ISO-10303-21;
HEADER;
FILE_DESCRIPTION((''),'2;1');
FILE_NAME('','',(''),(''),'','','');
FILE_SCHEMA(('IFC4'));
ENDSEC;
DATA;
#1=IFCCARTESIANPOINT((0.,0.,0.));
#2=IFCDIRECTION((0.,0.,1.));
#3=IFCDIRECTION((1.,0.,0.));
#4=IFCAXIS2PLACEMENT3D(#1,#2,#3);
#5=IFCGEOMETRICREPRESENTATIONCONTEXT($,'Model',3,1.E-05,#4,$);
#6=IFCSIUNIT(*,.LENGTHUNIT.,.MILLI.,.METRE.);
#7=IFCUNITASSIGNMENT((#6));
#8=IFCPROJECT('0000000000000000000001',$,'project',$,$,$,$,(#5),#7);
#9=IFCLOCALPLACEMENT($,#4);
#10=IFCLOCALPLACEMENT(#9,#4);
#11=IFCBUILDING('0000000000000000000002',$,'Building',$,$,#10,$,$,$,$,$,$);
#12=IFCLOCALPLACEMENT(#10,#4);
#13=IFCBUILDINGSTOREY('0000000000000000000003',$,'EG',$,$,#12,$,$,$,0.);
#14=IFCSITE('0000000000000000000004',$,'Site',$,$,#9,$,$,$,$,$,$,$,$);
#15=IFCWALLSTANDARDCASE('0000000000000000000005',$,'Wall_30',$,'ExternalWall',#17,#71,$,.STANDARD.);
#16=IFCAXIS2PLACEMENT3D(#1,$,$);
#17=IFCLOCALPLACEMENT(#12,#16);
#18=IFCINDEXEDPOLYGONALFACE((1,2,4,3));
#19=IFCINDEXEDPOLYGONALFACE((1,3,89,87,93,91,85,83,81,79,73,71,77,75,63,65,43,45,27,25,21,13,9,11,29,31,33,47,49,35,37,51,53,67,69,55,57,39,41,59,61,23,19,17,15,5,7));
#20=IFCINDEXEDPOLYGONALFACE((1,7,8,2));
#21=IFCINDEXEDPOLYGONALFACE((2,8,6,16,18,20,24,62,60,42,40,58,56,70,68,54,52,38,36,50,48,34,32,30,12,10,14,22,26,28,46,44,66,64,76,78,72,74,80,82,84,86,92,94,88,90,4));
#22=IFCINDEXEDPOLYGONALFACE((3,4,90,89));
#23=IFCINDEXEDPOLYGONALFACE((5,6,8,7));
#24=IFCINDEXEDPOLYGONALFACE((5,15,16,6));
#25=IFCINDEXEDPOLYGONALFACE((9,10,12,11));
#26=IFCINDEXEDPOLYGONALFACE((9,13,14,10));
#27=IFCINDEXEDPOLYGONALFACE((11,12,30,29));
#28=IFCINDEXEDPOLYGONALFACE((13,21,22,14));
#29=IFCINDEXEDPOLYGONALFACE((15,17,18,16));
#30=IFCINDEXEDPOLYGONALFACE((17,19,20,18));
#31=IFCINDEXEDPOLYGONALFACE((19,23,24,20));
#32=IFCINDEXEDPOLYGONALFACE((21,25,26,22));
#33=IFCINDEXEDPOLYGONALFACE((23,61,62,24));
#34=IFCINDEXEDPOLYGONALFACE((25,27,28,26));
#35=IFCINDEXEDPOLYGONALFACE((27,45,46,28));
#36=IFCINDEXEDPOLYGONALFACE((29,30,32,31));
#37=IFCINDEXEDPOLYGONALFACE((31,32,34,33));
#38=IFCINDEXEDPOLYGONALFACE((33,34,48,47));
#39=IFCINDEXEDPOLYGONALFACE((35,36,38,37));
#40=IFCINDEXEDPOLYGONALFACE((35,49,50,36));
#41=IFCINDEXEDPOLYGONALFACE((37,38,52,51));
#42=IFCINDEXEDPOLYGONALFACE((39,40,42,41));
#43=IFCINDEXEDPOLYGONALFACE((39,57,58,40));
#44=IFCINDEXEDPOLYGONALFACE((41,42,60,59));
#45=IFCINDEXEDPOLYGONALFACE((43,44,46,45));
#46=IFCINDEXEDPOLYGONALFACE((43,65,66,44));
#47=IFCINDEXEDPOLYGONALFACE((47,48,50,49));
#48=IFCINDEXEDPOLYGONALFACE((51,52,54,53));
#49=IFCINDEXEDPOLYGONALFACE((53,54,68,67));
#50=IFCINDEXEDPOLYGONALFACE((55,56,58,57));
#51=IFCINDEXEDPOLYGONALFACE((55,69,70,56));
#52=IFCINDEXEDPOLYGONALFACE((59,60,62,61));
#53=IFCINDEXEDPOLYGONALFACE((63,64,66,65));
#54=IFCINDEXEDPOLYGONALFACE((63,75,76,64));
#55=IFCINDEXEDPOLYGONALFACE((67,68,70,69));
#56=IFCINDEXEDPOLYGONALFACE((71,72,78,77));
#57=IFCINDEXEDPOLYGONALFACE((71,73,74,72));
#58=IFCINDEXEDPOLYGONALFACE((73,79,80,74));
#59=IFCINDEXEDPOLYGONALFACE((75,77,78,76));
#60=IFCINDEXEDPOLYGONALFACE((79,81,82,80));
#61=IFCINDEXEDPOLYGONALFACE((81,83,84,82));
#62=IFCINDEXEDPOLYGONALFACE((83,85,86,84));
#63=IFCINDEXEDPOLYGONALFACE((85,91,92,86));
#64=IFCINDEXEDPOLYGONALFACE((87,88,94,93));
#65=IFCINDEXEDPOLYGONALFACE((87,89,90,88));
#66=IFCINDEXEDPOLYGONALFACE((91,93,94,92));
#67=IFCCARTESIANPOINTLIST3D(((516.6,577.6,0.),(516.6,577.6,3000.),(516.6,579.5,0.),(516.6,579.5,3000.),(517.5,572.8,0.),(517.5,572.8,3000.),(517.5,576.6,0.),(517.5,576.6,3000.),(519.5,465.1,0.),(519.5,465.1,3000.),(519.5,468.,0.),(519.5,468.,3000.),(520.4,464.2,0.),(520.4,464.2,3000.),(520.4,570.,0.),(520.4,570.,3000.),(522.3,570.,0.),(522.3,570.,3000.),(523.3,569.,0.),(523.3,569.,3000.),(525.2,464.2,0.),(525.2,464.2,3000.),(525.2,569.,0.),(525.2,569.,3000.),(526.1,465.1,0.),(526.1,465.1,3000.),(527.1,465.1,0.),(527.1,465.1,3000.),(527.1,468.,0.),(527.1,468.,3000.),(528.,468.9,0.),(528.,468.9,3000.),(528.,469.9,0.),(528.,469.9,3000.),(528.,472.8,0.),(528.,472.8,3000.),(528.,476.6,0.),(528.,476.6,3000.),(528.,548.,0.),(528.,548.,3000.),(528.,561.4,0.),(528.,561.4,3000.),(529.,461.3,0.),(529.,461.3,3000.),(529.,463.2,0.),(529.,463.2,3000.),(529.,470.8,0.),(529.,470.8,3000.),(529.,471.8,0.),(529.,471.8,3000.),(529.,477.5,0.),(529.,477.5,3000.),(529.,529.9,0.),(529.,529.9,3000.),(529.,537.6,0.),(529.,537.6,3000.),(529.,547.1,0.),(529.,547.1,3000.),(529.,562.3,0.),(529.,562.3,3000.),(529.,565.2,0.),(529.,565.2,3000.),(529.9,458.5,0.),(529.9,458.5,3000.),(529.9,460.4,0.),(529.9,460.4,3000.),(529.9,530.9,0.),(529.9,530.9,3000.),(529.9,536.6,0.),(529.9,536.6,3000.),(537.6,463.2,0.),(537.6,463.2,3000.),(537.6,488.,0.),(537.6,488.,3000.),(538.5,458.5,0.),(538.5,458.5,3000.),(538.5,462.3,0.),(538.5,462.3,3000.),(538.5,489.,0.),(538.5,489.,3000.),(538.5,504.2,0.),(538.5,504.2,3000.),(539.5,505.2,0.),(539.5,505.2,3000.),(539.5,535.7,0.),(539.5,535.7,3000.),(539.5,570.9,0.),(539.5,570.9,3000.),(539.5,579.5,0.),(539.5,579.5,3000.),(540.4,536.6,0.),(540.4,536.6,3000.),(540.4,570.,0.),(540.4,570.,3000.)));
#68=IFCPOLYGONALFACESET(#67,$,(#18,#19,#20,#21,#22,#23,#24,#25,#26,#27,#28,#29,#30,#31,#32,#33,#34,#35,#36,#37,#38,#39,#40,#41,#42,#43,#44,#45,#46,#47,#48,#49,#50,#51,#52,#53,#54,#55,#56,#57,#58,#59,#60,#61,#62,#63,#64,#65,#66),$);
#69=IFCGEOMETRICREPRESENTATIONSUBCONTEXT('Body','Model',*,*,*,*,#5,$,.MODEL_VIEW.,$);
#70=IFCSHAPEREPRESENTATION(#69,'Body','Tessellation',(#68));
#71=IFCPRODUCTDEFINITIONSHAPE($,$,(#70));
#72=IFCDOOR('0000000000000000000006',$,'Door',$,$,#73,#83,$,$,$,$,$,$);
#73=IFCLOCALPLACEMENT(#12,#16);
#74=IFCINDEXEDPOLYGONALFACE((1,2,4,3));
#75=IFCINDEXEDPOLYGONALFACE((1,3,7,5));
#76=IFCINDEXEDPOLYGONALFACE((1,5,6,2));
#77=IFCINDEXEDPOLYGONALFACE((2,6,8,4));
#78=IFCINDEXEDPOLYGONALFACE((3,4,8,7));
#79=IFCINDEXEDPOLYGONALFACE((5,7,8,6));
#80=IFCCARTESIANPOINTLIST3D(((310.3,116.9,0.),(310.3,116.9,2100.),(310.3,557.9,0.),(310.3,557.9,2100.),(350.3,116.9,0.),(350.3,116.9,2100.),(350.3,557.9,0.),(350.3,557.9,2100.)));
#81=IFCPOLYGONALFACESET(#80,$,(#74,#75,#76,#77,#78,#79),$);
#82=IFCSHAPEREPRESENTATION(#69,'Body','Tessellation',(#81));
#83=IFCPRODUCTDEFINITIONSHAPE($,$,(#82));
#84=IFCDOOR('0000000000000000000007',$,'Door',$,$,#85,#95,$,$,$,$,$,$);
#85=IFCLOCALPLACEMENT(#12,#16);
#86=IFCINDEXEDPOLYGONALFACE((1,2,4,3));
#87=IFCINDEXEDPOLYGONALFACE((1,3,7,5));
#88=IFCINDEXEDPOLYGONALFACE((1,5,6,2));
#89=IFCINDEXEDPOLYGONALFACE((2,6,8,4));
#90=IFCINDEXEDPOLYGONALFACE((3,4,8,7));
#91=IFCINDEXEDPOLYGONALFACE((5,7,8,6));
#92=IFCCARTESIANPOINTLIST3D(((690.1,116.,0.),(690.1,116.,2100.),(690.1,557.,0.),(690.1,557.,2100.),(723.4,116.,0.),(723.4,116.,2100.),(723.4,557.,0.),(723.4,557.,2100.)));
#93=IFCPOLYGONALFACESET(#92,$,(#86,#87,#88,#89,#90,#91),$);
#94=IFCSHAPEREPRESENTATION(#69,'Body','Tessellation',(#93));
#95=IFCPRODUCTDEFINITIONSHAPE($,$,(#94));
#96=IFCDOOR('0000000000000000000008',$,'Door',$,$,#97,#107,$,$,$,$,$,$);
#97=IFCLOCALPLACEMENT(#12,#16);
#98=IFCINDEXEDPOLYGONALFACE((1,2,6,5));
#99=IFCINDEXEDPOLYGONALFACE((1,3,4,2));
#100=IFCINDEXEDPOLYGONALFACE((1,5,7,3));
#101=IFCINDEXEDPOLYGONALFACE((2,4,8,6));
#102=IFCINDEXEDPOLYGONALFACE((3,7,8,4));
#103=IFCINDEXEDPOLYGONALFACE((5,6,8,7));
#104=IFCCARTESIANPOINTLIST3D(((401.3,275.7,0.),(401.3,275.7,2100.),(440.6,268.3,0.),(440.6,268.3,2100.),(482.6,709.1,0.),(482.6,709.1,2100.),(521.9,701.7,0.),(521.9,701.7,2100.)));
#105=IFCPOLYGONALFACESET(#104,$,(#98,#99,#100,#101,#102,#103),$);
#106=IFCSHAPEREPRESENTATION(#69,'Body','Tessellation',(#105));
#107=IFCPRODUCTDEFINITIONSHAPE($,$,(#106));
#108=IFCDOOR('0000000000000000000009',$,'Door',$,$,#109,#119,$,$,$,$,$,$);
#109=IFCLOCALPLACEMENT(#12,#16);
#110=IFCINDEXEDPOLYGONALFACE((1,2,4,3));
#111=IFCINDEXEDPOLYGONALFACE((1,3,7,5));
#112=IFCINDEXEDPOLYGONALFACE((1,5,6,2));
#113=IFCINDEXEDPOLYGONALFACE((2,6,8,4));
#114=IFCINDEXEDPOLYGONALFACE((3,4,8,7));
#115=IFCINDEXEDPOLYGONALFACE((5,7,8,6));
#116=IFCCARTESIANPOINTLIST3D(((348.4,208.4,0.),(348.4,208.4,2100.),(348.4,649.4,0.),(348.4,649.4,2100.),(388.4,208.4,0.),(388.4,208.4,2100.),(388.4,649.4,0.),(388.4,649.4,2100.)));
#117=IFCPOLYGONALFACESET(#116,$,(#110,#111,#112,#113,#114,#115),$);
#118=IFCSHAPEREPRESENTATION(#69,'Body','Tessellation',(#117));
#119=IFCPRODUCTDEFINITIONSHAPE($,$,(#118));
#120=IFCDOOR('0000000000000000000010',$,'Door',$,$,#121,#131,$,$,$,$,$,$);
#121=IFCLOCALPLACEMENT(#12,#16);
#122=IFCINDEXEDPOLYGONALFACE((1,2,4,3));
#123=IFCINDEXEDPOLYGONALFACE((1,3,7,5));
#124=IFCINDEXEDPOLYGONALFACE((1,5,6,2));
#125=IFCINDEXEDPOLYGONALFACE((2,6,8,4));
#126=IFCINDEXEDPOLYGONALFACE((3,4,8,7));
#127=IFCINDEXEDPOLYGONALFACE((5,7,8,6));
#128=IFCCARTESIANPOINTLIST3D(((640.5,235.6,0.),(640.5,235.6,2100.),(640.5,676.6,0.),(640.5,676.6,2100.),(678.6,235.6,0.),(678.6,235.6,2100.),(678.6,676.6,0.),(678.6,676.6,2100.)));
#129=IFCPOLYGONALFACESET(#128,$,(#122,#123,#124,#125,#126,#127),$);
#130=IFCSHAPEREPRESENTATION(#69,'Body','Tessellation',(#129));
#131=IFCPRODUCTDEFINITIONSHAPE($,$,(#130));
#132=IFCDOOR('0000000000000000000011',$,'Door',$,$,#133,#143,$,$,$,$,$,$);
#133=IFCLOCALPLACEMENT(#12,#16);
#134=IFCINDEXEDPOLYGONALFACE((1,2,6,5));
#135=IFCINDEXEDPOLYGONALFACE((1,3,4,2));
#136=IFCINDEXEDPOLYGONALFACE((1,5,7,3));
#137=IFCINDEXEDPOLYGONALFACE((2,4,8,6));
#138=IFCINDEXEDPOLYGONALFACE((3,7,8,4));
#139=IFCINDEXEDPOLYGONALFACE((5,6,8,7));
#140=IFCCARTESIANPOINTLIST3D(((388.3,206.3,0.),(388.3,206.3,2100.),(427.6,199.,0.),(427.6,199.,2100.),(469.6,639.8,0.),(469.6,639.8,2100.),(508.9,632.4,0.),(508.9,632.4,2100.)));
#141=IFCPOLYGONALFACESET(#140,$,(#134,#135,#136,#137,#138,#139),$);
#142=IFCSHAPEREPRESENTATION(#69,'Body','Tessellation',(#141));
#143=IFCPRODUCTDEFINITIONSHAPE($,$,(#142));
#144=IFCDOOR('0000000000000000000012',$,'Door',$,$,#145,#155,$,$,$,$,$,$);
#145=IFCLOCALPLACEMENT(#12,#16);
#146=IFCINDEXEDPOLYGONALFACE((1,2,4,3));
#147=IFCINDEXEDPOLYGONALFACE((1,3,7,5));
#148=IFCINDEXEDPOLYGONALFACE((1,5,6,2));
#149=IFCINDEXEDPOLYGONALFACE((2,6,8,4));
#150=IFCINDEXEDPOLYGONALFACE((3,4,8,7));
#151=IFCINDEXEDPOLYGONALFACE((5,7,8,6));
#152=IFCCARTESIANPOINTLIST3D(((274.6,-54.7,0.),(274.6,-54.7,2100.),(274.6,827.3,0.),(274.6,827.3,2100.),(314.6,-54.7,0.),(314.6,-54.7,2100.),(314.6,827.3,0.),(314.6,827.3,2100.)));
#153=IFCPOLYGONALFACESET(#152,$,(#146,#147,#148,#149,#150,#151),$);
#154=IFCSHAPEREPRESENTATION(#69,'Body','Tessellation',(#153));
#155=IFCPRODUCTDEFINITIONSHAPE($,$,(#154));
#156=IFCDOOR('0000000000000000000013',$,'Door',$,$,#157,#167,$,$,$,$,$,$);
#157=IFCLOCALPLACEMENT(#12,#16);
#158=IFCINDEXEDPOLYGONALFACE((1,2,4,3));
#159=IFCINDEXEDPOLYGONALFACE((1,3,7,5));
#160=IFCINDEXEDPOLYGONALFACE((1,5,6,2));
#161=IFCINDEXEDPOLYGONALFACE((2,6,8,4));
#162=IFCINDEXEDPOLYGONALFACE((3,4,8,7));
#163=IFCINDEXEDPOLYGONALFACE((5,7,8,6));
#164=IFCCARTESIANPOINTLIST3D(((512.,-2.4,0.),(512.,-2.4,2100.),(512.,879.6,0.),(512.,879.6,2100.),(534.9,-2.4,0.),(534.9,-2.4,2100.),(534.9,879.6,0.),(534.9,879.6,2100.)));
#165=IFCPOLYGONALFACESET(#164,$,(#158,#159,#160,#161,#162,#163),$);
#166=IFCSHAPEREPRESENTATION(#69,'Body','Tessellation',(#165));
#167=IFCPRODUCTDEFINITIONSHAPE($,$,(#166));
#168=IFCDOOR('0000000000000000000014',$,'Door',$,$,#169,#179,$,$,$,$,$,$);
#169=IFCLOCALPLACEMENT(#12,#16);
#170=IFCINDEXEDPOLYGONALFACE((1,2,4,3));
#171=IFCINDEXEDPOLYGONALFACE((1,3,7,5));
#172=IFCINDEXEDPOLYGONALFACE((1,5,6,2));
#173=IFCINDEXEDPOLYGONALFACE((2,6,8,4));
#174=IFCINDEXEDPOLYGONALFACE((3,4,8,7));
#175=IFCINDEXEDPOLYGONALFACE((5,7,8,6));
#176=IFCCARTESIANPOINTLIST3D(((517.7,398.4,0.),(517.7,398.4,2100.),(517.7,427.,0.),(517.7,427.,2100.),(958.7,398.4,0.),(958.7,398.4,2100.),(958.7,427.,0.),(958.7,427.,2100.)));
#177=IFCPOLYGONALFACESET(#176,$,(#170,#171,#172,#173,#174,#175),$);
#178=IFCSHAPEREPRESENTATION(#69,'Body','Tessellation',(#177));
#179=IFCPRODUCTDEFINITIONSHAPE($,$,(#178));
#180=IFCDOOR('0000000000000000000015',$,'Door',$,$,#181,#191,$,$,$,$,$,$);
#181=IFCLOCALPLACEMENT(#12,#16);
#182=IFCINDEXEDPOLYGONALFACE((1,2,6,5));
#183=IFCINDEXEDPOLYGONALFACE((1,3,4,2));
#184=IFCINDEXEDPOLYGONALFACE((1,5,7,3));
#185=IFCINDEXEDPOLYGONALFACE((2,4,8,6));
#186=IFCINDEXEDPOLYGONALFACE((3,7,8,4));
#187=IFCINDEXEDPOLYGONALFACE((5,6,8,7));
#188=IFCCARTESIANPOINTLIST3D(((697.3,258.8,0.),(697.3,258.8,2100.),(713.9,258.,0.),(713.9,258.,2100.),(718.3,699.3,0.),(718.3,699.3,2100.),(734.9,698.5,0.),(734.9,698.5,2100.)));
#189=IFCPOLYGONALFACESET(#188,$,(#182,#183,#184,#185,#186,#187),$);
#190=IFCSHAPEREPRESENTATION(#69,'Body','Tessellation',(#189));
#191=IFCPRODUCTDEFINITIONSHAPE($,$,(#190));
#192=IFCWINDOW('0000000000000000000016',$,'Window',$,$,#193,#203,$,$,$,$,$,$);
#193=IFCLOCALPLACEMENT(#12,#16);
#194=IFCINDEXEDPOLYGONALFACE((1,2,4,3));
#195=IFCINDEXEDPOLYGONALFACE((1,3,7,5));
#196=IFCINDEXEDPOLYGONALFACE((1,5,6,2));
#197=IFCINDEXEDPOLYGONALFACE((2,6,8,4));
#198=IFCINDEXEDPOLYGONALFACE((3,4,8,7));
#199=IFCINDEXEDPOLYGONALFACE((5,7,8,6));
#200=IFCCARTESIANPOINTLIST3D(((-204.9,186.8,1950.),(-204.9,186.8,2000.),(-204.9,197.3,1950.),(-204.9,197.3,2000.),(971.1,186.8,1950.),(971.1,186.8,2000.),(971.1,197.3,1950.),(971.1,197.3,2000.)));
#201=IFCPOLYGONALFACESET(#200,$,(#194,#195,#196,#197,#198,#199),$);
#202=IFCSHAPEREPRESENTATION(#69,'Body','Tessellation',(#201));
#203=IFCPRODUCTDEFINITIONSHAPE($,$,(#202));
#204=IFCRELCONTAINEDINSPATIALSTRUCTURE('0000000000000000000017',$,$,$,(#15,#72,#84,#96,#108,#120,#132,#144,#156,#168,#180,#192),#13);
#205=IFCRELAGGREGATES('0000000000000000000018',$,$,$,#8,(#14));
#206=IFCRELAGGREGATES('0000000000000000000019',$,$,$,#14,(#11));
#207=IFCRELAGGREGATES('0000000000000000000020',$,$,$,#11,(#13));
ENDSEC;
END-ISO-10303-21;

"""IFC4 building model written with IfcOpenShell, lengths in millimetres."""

from ifc_helpers import new_model, si_unit, frame, origin_with_axes, place, context, subcontext, project, spatial, polyline, rectangle, outline, extrude, element, save


model = new_model("IFC4")

# Units and contexts
model_context = context("Model", 3, precision=1e-05, world=origin_with_axes())
body_context = subcontext(model_context, "Body", "Model", "MODEL_VIEW")
ifc_project = project(units=[si_unit("LENGTHUNIT", "METRE", prefix="MILLI")], contexts=[model_context])

# Site, building, storey
site_placement = place(None, origin_with_axes())
site = spatial("IfcSite", under=ifc_project, at=site_placement, Name="Site")
building_placement = place(site_placement, origin_with_axes())
building = spatial("IfcBuilding", under=site, at=building_placement, Name="Building")
storey_placement = place(building_placement, origin_with_axes())
storey = spatial("IfcBuildingStorey", under=building, at=storey_placement, Name="EG", Elevation=0.0)

# Wall
wall_placement = place(storey_placement, origin_with_axes())
element("IfcWallStandardCase", 1, at=wall_placement, inside=storey, Name="Wall_30", ObjectType="ExternalWall", PredefinedType="STANDARD", context=body_context, shape_type="SweptSolid", body=[
    extrude(outline(polyline([(529.9, 458.5, 0.0), (529.9, 460.4, 0.0), (529.0, 461.3, 0.0), (529.0, 463.2, 0.0), (527.1, 465.1, 0.0), (526.1, 465.1, 0.0), (525.2, 464.2, 0.0), (520.4, 464.2, 0.0), (519.5, 465.1, 0.0), (519.5, 468.0, 0.0), (527.1, 468.0, 0.0), (528.0, 468.9, 0.0), (528.0, 469.9, 0.0), (529.0, 470.8, 0.0), (529.0, 471.8, 0.0), (528.0, 472.8, 0.0), (528.0, 476.6, 0.0), (529.0, 477.5, 0.0), (529.0, 529.9, 0.0), (529.9, 530.9, 0.0), (529.9, 536.6, 0.0), (529.0, 537.6, 0.0), (529.0, 547.1, 0.0), (528.0, 548.0, 0.0), (528.0, 561.4, 0.0), (529.0, 562.3, 0.0), (529.0, 565.2, 0.0), (525.2, 569.0, 0.0), (523.3, 569.0, 0.0), (522.3, 570.0, 0.0), (520.4, 570.0, 0.0), (517.5, 572.8, 0.0), (517.5, 576.6, 0.0), (516.6, 577.6, 0.0), (516.6, 579.5, 0.0), (539.5, 579.5, 0.0), (539.5, 570.9, 0.0), (540.4, 570.0, 0.0), (540.4, 536.6, 0.0), (539.5, 535.7, 0.0), (539.5, 505.2, 0.0), (538.5, 504.2, 0.0), (538.5, 489.0, 0.0), (537.6, 488.0, 0.0), (537.6, 463.2, 0.0), (538.5, 462.3, 0.0), (538.5, 458.5, 0.0), (529.9, 458.5, 0.0)])), origin_with_axes(), (0.0, 0.0, 1.0), 3000.0),
])

# Doors
door_1_placement = place(storey_placement, origin_with_axes())
element("IfcDoor", 2, at=door_1_placement, inside=storey, Name="Door", context=body_context, shape_type="SweptSolid", body=[
    extrude(rectangle(XDim=441.0, YDim=40.0), frame((330.3, 337.4, 0.0), z_axis=(0.0, 0.0, 1.0), x_axis=(0.0, 1.0, 0.0)), (0.0, 0.0, 1.0), 2100.0),
])
door_2_placement = place(storey_placement, origin_with_axes())
element("IfcDoor", 3, at=door_2_placement, inside=storey, Name="Door", context=body_context, shape_type="SweptSolid", body=[
    extrude(rectangle(XDim=441.0, YDim=33.4), frame((706.7, 336.5, 0.0), z_axis=(0.0, 0.0, 1.0), x_axis=(0.0, 1.0, 0.0)), (0.0, 0.0, 1.0), 2100.0),
])
door_3_placement = place(storey_placement, origin_with_axes())
element("IfcDoor", 4, at=door_3_placement, inside=storey, Name="Door", context=body_context, shape_type="SweptSolid", body=[
    extrude(rectangle(XDim=441.0, YDim=40.0), frame((461.6, 488.7, 0.0), z_axis=(0.0, 0.0, 1.0), x_axis=(-0.184288, -0.982872, 0.0)), (0.0, 0.0, 1.0), 2100.0),
])
door_4_placement = place(storey_placement, origin_with_axes())
element("IfcDoor", 5, at=door_4_placement, inside=storey, Name="Door", context=body_context, shape_type="SweptSolid", body=[
    extrude(rectangle(XDim=441.0, YDim=40.0), frame((368.4, 428.9, 0.0), z_axis=(0.0, 0.0, 1.0), x_axis=(0.0, -1.0, 0.0)), (0.0, 0.0, 1.0), 2100.0),
])
door_5_placement = place(storey_placement, origin_with_axes())
element("IfcDoor", 6, at=door_5_placement, inside=storey, Name="Door", context=body_context, shape_type="SweptSolid", body=[
    extrude(rectangle(XDim=441.0, YDim=38.1), frame((659.6, 456.1, 0.0), z_axis=(0.0, 0.0, 1.0), x_axis=(0.0, 1.0, 0.0)), (0.0, 0.0, 1.0), 2100.0),
])
door_6_placement = place(storey_placement, origin_with_axes())
element("IfcDoor", 7, at=door_6_placement, inside=storey, Name="Door", context=body_context, shape_type="SweptSolid", body=[
    extrude(rectangle(XDim=441.0, YDim=40.0), frame((448.6, 419.4, 0.0), z_axis=(0.0, 0.0, 1.0), x_axis=(-0.184288, -0.982872, 0.0)), (0.0, 0.0, 1.0), 2100.0),
])
door_7_placement = place(storey_placement, origin_with_axes())
element("IfcDoor", 8, at=door_7_placement, inside=storey, Name="Door", context=body_context, shape_type="SweptSolid", body=[
    extrude(rectangle(XDim=882.0, YDim=40.0), frame((294.6, 386.3, 0.0), z_axis=(0.0, 0.0, 1.0), x_axis=(0.0, 1.0, 0.0)), (0.0, 0.0, 1.0), 2100.0),
])
door_8_placement = place(storey_placement, origin_with_axes())
element("IfcDoor", 9, at=door_8_placement, inside=storey, Name="Door", context=body_context, shape_type="SweptSolid", body=[
    extrude(rectangle(XDim=882.0, YDim=22.9), frame((523.4, 438.6, 0.0), z_axis=(0.0, 0.0, 1.0), x_axis=(0.0, 1.0, 0.0)), (0.0, 0.0, 1.0), 2100.0),
])
door_9_placement = place(storey_placement, origin_with_axes())
element("IfcDoor", 10, at=door_9_placement, inside=storey, Name="Door", context=body_context, shape_type="SweptSolid", body=[
    extrude(rectangle(XDim=441.0, YDim=28.6), frame((738.2, 412.7, 0.0), z_axis=(0.0, 0.0, 1.0), x_axis=(1.0, 0.0, 0.0)), (0.0, 0.0, 1.0), 2100.0),
])
door_10_placement = place(storey_placement, origin_with_axes())
element("IfcDoor", 11, at=door_10_placement, inside=storey, Name="Door", context=body_context, shape_type="SweptSolid", body=[
    extrude(rectangle(XDim=441.0, YDim=16.6), frame((716.1, 478.6, 0.0), z_axis=(0.0, 0.0, 1.0), x_axis=(-0.047565, -0.998868, 0.0)), (0.0, 0.0, 1.0), 2100.0),
])

# Window
window_1_placement = place(storey_placement, origin_with_axes())
element("IfcWindow", 12, at=window_1_placement, inside=storey, Name="Window", context=body_context, shape_type="SweptSolid", body=[
    extrude(rectangle(XDim=1176.0, YDim=10.5), frame((383.1, 192.1, 1950.0), z_axis=(0.0, 0.0, 1.0), x_axis=(1.0, 0.0, 0.0)), (0.0, 0.0, 1.0), 50.0),
])

save(model, "model.ifc")
